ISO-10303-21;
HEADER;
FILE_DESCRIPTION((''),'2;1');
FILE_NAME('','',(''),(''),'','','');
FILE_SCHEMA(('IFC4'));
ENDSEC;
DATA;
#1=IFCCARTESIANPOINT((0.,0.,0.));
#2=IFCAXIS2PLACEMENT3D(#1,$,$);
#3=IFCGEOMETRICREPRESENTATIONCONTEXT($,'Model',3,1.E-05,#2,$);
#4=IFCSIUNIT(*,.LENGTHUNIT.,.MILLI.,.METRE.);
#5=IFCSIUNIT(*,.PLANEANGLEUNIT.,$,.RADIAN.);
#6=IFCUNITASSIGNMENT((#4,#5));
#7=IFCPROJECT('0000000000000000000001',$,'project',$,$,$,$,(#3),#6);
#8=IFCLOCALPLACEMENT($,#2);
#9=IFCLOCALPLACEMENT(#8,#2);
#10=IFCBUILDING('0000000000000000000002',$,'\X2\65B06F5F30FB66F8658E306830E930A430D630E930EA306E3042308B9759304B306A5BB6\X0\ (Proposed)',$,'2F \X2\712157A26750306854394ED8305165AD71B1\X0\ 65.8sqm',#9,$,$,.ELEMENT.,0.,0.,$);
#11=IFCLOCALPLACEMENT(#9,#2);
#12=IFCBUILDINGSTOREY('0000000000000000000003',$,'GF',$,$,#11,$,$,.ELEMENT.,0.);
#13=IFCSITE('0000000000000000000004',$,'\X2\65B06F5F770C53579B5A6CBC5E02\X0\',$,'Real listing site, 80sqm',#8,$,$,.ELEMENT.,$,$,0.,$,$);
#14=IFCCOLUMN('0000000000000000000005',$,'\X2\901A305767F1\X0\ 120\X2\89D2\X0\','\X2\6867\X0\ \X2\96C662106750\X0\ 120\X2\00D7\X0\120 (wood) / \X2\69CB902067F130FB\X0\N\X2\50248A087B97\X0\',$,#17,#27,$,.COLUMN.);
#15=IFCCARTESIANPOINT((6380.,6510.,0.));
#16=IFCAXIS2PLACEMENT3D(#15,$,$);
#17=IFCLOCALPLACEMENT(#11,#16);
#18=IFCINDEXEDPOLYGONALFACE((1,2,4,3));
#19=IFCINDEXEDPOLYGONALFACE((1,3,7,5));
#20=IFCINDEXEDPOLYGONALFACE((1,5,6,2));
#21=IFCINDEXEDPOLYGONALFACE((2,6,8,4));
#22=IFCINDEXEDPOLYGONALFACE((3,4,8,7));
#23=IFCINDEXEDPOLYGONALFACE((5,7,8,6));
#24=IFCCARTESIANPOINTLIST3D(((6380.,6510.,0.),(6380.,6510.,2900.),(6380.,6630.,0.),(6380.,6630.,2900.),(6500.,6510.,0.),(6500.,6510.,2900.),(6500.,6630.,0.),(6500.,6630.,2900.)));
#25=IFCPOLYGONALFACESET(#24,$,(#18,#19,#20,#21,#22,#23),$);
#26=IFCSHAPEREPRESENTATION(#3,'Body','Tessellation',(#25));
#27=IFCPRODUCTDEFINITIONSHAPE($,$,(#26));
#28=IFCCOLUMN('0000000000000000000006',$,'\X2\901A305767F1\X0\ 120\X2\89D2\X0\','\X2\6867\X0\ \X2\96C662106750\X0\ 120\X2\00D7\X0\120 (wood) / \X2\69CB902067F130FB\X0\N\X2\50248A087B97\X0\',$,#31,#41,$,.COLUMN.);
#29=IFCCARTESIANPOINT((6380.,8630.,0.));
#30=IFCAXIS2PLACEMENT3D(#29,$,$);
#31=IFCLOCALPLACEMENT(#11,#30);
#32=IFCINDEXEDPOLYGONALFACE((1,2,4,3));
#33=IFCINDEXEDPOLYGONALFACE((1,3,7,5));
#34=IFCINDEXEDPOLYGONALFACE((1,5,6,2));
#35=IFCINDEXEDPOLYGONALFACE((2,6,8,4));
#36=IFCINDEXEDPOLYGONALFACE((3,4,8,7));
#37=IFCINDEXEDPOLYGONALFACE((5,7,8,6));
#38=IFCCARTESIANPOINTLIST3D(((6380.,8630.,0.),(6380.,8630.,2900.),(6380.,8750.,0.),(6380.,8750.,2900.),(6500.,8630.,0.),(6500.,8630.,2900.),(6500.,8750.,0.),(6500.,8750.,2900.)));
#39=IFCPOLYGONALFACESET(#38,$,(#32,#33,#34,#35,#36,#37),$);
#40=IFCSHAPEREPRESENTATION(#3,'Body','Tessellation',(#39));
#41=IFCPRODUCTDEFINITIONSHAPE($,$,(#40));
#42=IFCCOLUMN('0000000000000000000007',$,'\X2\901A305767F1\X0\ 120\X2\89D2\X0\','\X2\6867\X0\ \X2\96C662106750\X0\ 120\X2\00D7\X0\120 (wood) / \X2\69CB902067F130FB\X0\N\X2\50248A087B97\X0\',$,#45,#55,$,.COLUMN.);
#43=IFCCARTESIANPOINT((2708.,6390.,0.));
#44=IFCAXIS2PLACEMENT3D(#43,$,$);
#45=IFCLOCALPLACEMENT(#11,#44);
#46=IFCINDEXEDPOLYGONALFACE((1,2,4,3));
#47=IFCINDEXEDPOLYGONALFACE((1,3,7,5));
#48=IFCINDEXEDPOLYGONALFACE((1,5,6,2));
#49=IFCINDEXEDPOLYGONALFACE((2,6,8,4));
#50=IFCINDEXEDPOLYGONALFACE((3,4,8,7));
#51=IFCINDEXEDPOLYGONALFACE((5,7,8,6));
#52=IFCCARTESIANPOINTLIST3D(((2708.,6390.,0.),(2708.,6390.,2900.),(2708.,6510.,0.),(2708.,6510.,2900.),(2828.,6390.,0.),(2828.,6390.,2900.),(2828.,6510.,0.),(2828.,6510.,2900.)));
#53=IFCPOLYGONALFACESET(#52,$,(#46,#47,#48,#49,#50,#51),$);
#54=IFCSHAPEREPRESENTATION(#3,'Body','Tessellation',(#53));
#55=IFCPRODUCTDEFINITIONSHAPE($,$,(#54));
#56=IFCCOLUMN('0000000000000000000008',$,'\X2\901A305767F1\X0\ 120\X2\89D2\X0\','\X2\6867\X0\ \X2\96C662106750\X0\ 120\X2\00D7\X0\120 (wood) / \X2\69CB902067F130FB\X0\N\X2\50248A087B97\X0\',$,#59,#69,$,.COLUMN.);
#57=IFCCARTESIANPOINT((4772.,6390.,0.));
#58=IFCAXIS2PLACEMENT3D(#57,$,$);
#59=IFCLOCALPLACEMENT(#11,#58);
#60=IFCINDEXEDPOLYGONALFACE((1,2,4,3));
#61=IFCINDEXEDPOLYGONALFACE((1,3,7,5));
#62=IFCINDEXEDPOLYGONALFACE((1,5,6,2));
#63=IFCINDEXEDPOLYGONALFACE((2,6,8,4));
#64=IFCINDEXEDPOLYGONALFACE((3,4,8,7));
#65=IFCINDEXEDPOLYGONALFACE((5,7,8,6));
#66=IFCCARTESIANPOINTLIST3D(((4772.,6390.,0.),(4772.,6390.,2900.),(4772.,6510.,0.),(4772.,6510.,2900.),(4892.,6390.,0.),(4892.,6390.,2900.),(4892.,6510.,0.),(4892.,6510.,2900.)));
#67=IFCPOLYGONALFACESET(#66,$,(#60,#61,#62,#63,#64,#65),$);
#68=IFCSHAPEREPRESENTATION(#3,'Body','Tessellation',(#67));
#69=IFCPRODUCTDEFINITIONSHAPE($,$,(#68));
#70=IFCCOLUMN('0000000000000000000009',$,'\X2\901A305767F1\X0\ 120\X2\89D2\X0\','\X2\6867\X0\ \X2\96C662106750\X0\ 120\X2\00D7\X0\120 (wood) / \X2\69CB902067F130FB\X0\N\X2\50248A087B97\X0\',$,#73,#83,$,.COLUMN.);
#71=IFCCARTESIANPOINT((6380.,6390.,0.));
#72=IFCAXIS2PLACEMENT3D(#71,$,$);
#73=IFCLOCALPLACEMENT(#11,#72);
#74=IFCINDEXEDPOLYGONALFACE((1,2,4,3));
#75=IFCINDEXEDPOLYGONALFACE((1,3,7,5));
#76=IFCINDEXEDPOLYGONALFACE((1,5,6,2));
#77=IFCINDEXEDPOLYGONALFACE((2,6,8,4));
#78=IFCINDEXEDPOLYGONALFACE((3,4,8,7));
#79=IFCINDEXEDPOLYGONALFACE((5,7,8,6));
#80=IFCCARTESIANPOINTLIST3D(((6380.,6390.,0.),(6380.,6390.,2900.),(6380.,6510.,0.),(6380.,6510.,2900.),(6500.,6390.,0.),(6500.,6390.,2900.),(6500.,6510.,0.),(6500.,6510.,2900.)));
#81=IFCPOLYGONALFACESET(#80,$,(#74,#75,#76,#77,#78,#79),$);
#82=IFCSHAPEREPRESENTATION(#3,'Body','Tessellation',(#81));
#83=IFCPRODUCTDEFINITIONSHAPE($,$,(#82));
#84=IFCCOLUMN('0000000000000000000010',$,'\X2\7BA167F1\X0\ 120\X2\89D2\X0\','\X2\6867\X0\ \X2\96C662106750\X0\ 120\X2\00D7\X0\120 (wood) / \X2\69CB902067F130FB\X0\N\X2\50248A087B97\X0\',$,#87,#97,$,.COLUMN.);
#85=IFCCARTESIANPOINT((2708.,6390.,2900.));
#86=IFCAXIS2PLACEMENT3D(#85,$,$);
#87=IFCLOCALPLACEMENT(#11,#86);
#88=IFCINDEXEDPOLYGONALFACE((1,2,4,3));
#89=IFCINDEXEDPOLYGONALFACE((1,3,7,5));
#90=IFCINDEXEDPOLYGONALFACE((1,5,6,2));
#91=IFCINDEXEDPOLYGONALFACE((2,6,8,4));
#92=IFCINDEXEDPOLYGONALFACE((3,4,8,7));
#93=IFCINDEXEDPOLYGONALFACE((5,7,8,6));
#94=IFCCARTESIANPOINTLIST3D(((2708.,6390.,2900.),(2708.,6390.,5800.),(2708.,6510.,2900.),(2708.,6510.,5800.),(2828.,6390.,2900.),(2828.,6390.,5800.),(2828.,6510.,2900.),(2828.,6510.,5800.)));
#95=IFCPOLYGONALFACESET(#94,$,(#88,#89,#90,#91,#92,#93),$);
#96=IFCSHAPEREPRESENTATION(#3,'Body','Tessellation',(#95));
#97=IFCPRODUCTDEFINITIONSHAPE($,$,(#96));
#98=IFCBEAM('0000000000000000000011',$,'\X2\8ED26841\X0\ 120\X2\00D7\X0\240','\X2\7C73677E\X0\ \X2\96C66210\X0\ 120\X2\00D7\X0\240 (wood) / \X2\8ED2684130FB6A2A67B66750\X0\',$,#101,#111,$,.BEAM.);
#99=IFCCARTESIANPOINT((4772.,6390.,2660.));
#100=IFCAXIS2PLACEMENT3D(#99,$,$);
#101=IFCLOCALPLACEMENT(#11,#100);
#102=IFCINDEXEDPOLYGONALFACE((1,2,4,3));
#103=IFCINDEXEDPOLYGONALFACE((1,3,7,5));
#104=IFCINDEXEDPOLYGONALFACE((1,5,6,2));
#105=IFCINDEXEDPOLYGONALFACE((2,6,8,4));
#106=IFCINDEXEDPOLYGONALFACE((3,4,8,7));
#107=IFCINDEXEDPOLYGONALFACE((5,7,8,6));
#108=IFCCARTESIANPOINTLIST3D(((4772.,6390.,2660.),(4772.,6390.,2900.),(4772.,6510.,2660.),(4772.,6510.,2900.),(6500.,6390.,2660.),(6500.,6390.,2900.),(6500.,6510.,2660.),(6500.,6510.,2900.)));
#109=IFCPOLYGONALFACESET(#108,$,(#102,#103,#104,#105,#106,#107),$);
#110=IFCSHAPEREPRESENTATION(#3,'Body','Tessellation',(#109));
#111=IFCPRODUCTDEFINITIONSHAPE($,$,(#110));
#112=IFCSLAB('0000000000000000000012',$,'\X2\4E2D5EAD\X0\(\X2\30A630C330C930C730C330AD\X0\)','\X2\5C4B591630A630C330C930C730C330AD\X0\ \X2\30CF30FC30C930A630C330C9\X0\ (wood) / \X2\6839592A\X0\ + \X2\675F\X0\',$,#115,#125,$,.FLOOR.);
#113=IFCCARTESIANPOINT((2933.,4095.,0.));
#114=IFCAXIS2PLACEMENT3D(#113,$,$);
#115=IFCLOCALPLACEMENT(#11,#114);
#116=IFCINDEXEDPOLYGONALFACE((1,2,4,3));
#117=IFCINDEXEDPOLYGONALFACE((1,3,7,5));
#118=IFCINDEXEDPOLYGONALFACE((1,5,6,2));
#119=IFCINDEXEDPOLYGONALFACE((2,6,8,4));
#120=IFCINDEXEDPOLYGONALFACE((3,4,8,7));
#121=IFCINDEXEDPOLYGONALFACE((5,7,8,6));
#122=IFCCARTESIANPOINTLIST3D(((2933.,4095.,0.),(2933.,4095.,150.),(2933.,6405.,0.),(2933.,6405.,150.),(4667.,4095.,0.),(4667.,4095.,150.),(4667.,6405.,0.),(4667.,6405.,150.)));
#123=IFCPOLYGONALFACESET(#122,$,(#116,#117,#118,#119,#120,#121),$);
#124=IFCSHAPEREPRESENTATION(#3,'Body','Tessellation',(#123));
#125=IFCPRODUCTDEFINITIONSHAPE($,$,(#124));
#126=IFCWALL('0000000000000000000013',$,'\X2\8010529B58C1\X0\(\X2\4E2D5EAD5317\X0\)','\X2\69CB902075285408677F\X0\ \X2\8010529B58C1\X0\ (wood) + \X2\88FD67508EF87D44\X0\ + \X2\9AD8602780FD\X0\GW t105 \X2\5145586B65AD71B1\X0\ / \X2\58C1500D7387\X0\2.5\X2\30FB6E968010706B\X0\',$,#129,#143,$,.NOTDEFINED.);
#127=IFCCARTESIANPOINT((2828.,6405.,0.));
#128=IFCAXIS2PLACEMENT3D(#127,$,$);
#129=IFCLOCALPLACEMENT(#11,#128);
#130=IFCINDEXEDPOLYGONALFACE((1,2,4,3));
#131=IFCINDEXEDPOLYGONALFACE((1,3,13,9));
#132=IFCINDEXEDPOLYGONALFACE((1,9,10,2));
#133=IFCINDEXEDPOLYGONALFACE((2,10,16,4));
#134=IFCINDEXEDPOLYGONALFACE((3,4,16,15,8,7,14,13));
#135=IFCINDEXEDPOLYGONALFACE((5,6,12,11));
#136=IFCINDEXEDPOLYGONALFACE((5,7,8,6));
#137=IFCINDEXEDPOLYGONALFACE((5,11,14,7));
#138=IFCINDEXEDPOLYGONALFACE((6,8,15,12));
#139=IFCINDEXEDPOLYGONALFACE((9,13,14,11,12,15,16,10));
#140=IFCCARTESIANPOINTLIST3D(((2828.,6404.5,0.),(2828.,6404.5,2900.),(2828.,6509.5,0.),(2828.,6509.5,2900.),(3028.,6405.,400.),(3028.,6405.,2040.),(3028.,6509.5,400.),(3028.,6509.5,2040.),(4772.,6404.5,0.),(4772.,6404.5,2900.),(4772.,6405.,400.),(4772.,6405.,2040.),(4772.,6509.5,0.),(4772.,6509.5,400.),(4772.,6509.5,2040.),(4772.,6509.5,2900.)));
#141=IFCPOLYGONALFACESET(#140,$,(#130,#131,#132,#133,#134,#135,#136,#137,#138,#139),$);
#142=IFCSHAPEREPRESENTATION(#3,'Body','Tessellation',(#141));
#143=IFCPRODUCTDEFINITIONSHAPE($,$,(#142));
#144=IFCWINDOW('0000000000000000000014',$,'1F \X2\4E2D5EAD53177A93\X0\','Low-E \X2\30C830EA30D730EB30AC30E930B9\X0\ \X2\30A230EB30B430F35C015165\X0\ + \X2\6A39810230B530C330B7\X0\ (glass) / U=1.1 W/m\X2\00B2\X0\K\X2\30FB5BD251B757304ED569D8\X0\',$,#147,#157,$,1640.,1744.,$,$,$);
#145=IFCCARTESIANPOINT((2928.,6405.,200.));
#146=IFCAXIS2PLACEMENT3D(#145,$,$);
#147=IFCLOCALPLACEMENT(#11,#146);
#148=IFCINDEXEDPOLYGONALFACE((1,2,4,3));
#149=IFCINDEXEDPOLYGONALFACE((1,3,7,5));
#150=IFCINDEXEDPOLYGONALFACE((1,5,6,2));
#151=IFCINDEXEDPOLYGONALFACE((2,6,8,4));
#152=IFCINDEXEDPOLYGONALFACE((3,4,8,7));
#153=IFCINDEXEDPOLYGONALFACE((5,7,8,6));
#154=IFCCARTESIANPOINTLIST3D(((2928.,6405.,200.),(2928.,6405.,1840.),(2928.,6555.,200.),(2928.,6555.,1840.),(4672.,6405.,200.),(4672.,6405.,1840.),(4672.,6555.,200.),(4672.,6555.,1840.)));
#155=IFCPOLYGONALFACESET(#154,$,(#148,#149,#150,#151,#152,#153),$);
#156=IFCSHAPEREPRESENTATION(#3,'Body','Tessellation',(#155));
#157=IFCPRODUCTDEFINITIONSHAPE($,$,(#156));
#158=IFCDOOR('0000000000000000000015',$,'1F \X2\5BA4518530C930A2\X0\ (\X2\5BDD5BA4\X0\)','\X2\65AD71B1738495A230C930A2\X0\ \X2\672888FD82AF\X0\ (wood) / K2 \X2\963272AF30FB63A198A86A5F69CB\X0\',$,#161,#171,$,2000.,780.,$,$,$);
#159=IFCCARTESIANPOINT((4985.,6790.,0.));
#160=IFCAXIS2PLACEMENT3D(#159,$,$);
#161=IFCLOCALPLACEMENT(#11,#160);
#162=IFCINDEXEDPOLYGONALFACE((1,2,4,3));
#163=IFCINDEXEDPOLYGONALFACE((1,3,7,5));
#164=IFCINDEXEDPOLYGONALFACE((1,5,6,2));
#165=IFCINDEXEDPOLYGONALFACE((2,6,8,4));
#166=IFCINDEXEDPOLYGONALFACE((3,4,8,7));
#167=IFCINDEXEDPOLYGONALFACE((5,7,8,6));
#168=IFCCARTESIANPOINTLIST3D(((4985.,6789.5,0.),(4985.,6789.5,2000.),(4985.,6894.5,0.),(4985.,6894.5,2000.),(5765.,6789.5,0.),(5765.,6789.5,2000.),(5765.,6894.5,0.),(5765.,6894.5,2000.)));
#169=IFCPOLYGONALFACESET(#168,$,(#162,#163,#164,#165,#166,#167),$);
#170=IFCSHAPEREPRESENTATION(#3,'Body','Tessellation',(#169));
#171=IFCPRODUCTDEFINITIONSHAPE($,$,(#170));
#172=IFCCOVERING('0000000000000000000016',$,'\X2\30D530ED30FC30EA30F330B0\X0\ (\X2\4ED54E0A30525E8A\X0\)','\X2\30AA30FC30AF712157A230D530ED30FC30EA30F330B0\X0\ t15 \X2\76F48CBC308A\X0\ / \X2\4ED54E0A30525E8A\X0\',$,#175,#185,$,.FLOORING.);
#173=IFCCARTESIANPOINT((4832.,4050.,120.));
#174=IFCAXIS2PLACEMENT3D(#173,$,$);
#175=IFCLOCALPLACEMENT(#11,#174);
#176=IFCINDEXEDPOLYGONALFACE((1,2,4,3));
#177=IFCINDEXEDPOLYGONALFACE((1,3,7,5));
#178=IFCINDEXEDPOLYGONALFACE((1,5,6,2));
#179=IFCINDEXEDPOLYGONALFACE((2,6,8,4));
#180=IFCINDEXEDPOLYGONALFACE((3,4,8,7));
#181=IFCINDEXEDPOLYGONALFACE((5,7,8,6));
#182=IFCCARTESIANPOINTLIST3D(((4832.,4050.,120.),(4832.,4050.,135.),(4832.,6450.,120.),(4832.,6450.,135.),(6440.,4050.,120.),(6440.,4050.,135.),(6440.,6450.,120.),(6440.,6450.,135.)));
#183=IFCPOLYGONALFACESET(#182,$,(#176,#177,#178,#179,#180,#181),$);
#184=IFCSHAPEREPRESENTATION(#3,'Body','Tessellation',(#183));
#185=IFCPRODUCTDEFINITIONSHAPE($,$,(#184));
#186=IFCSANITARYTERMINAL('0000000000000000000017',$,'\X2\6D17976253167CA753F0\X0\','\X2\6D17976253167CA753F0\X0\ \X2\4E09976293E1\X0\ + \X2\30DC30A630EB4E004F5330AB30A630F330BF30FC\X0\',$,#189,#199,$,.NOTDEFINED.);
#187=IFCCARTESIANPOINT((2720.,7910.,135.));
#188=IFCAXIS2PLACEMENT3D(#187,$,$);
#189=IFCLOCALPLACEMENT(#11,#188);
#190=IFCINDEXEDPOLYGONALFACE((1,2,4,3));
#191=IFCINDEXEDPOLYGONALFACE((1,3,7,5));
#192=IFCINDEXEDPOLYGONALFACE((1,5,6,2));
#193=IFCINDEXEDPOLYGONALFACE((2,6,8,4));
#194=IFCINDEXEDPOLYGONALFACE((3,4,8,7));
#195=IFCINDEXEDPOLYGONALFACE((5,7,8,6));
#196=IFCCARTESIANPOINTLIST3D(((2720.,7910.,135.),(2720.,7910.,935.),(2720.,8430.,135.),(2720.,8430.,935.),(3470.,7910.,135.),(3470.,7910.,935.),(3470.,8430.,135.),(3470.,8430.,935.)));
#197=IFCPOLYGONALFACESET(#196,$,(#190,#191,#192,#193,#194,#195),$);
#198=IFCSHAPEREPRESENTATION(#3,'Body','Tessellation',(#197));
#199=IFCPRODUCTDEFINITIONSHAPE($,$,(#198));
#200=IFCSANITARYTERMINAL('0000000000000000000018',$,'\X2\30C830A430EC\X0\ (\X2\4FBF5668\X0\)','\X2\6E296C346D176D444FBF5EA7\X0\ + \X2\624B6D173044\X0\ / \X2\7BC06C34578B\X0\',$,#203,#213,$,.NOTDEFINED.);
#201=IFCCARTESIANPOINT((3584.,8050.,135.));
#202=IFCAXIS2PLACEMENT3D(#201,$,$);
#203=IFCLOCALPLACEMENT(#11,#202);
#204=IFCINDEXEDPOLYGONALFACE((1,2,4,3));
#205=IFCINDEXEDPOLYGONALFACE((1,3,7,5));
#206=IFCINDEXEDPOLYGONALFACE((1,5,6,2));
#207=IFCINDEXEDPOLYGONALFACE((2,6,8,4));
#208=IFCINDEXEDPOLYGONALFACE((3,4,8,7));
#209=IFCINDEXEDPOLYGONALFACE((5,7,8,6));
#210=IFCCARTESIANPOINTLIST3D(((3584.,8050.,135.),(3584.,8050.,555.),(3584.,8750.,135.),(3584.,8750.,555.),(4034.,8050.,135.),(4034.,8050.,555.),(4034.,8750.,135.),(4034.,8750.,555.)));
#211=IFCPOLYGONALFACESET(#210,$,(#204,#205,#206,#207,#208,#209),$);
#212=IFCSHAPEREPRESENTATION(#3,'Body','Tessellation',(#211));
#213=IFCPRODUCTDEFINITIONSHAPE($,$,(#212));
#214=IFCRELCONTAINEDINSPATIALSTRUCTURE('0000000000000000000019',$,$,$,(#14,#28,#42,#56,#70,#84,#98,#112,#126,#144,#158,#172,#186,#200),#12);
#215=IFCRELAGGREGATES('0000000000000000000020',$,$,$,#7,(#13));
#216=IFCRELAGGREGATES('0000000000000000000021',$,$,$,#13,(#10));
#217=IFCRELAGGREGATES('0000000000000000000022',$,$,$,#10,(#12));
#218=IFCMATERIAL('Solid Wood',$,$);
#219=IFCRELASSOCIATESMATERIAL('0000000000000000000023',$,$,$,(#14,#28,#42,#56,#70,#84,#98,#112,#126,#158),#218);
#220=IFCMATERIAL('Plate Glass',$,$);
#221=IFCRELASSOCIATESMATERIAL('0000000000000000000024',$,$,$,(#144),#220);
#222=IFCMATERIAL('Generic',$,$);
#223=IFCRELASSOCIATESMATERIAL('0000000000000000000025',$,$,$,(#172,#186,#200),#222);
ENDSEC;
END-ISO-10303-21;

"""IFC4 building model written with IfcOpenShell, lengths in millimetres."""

from ifc_helpers import new_model, si_unit, frame, frame_2d, origin, place, context, project, spatial, rectangle, extrude, material, element, fill, save


model = new_model("IFC4")

# Units and contexts
model_context = context("Model", 3, precision=1e-05, world=origin())
ifc_project = project(units=[si_unit("LENGTHUNIT", "METRE", prefix="MILLI"), si_unit("PLANEANGLEUNIT", "RADIAN")], contexts=[model_context])

# Site, building, storey
site_placement = place(None, origin())
site = spatial("IfcSite", under=ifc_project, at=site_placement, Name="新潟県南魚沼市", ObjectType="Real listing site, 80sqm", CompositionType="ELEMENT", RefElevation=0.0)
building_placement = place(site_placement, origin())
building = spatial("IfcBuilding", under=site, at=building_placement, Name="新潟・書斎とライブラリのある静かな家 (Proposed)", ObjectType="2F 無垢材と吹付け断熱 65.8sqm", CompositionType="ELEMENT", ElevationOfRefHeight=0.0, ElevationOfTerrain=0.0)
storey_placement = place(building_placement, origin())
storey = spatial("IfcBuildingStorey", under=building, at=storey_placement, Name="GF", CompositionType="ELEMENT", Elevation=0.0)

# Columns
ifc_material_1 = material(Name="Solid Wood")
column_1_placement = place(storey_placement, frame((6380.0, 6510.0, 0.0)))
element("IfcColumn", 1, at=column_1_placement, inside=storey, material=ifc_material_1, Name="通し柱 120角", Description="桧 集成材 120×120 (wood) / 構造柱・N値計算", PredefinedType="COLUMN", context=model_context, shape_type="SweptSolid", body=[
    extrude(rectangle(XDim=120.0, YDim=120.0, at=frame_2d((60.0, 60.0))), frame((6380.0, 6510.0, 0.0)), (0.0, 0.0, 1.0), 2900.0),
])
column_2_placement = place(storey_placement, frame((6380.0, 8630.0, 0.0)))
element("IfcColumn", 2, at=column_2_placement, inside=storey, material=ifc_material_1, Name="通し柱 120角", Description="桧 集成材 120×120 (wood) / 構造柱・N値計算", PredefinedType="COLUMN", context=model_context, shape_type="SweptSolid", body=[
    extrude(rectangle(XDim=120.0, YDim=120.0, at=frame_2d((60.0, 60.0))), frame((6380.0, 8630.0, 0.0)), (0.0, 0.0, 1.0), 2900.0),
])
column_3_placement = place(storey_placement, frame((2708.0, 6390.0, 0.0)))
element("IfcColumn", 3, at=column_3_placement, inside=storey, material=ifc_material_1, Name="通し柱 120角", Description="桧 集成材 120×120 (wood) / 構造柱・N値計算", PredefinedType="COLUMN", context=model_context, shape_type="SweptSolid", body=[
    extrude(rectangle(XDim=120.0, YDim=120.0, at=frame_2d((60.0, 60.0))), frame((2708.0, 6390.0, 0.0)), (0.0, 0.0, 1.0), 2900.0),
])
column_4_placement = place(storey_placement, frame((4772.0, 6390.0, 0.0)))
element("IfcColumn", 4, at=column_4_placement, inside=storey, material=ifc_material_1, Name="通し柱 120角", Description="桧 集成材 120×120 (wood) / 構造柱・N値計算", PredefinedType="COLUMN", context=model_context, shape_type="SweptSolid", body=[
    extrude(rectangle(XDim=120.0, YDim=120.0, at=frame_2d((60.0, 60.0))), frame((4772.0, 6390.0, 0.0)), (0.0, 0.0, 1.0), 2900.0),
])
column_5_placement = place(storey_placement, frame((6380.0, 6390.0, 0.0)))
element("IfcColumn", 5, at=column_5_placement, inside=storey, material=ifc_material_1, Name="通し柱 120角", Description="桧 集成材 120×120 (wood) / 構造柱・N値計算", PredefinedType="COLUMN", context=model_context, shape_type="SweptSolid", body=[
    extrude(rectangle(XDim=120.0, YDim=120.0, at=frame_2d((60.0, 60.0))), frame((6380.0, 6390.0, 0.0)), (0.0, 0.0, 1.0), 2900.0),
])
column_6_placement = place(storey_placement, frame((2708.0, 6390.0, 2900.0)))
element("IfcColumn", 6, at=column_6_placement, inside=storey, material=ifc_material_1, Name="管柱 120角", Description="桧 集成材 120×120 (wood) / 構造柱・N値計算", PredefinedType="COLUMN", context=model_context, shape_type="SweptSolid", body=[
    extrude(rectangle(XDim=120.0, YDim=120.0, at=frame_2d((60.0, 60.0))), frame((2708.0, 6390.0, 2900.0)), (0.0, 0.0, 1.0), 2900.0),
])

# Beam
beam_1_placement = place(storey_placement, frame((4772.0, 6390.0, 2660.0)))
element("IfcBeam", 7, at=beam_1_placement, inside=storey, material=ifc_material_1, Name="軒桁 120×240", Description="米松 集成 120×240 (wood) / 軒桁・横架材", PredefinedType="BEAM", context=model_context, shape_type="SweptSolid", body=[
    extrude(rectangle(XDim=1728.0, YDim=120.0, at=frame_2d((864.0, 60.0))), frame((4772.0, 6390.0, 2660.0)), (0.0, 0.0, 1.0), 240.0),
])

# Slab
slab_placement = place(storey_placement, frame((2933.0, 4095.0, 0.0)))
element("IfcSlab", 8, at=slab_placement, inside=storey, material=ifc_material_1, Name="中庭(ウッドデッキ)", Description="屋外ウッドデッキ ハードウッド (wood) / 根太 + 束", PredefinedType="FLOOR", context=model_context, shape_type="SweptSolid", body=[
    extrude(rectangle(XDim=1734.0, YDim=2310.0, at=frame_2d((867.0, 1155.0))), frame((2933.0, 4095.0, 0.0)), (0.0, 0.0, 1.0), 150.0),
])

# Wall, opening, window
wall_1_placement = place(storey_placement, frame((2828.0, 6405.0, 0.0)))
wall_1 = element("IfcWall", 9, at=wall_1_placement, inside=storey, material=ifc_material_1, Name="耐力壁(中庭北)", Description="構造用合板 耐力壁 (wood) + 製材軸組 + 高性能GW t105 充填断熱 / 壁倍率2.5・準耐火", PredefinedType="NOTDEFINED", context=model_context, shape_type="SweptSolid", body=[
    extrude(rectangle(XDim=1944.0, YDim=105.0, at=frame_2d((972.0, 52.0))), frame((2828.0, 6405.0, 0.0)), (0.0, 0.0, 1.0), 2900.0),
])
opening_placement = place(storey_placement, frame((2928.0, 6405.0, 200.0)))
opening = element("IfcOpeningElement", 10, at=opening_placement, cuts=wall_1, PredefinedType="NOTDEFINED", context=model_context, shape_type="SweptSolid", body=[
    extrude(rectangle(XDim=1744.0, YDim=150.0, at=frame_2d((872.0, 75.0))), frame((2928.0, 6405.0, 200.0)), (0.0, 0.0, 1.0), 1640.0),
])
ifc_material_2 = material(Name="Plate Glass")
window_placement = place(storey_placement, frame((2928.0, 6405.0, 200.0)))
window = element("IfcWindow", 11, at=window_placement, inside=storey, material=ifc_material_2, Name="1F 中庭北窓", Description="Low-E トリプルガラス アルゴン封入 + 樹脂サッシ (glass) / U=1.1 W/m²K・寒冷地仕様", OverallHeight=1640.0, OverallWidth=1744.0, context=model_context, shape_type="SweptSolid", body=[
    extrude(rectangle(XDim=1744.0, YDim=150.0, at=frame_2d((872.0, 75.0))), frame((2928.0, 6405.0, 200.0)), (0.0, 0.0, 1.0), 1640.0),
])
fill(opening, window)

# Door
door_placement = place(storey_placement, frame((4985.0, 6790.0, 0.0)))
element("IfcDoor", 12, at=door_placement, inside=storey, material=ifc_material_1, Name="1F 室内ドア (寝室)", Description="断熱玄関ドア 木製芯 (wood) / K2 防犯・採風機構", OverallHeight=2000.0, OverallWidth=780.0, context=model_context, shape_type="SweptSolid", body=[
    extrude(rectangle(XDim=780.0, YDim=105.0, at=frame_2d((390.0, 52.0))), frame((4985.0, 6790.0, 0.0)), (0.0, 0.0, 1.0), 2000.0),
])

# Covering
ifc_material_3 = material(Name="Generic")
covering_placement = place(storey_placement, frame((4832.0, 4050.0, 120.0)))
element("IfcCovering", 13, at=covering_placement, inside=storey, material=ifc_material_3, Name="フローリング (仕上げ床)", Description="オーク無垢フローリング t15 直貼り / 仕上げ床", PredefinedType="FLOORING", context=model_context, shape_type="SweptSolid", body=[
    extrude(rectangle(XDim=1608.0, YDim=2400.0, at=frame_2d((804.0, 1200.0))), frame((4832.0, 4050.0, 120.0)), (0.0, 0.0, 1.0), 15.0),
])

# Sanitary terminals
sanitary_terminal_1_placement = place(storey_placement, frame((2720.0, 7910.0, 135.0)))
element("IfcSanitaryTerminal", 14, at=sanitary_terminal_1_placement, inside=storey, material=ifc_material_3, Name="洗面化粧台", Description="洗面化粧台 三面鏡 + ボウル一体カウンター", PredefinedType="NOTDEFINED", context=model_context, shape_type="SweptSolid", body=[
    extrude(rectangle(XDim=750.0, YDim=520.0, at=frame_2d((375.0, 260.0))), frame((2720.0, 7910.0, 135.0)), (0.0, 0.0, 1.0), 800.0),
])
sanitary_terminal_2_placement = place(storey_placement, frame((3584.0, 8050.0, 135.0)))
element("IfcSanitaryTerminal", 15, at=sanitary_terminal_2_placement, inside=storey, material=ifc_material_3, Name="トイレ (便器)", Description="温水洗浄便座 + 手洗い / 節水型", PredefinedType="NOTDEFINED", context=model_context, shape_type="SweptSolid", body=[
    extrude(rectangle(XDim=450.0, YDim=700.0, at=frame_2d((225.0, 350.0))), frame((3584.0, 8050.0, 135.0)), (0.0, 0.0, 1.0), 420.0),
])

save(model, "model.ifc")
